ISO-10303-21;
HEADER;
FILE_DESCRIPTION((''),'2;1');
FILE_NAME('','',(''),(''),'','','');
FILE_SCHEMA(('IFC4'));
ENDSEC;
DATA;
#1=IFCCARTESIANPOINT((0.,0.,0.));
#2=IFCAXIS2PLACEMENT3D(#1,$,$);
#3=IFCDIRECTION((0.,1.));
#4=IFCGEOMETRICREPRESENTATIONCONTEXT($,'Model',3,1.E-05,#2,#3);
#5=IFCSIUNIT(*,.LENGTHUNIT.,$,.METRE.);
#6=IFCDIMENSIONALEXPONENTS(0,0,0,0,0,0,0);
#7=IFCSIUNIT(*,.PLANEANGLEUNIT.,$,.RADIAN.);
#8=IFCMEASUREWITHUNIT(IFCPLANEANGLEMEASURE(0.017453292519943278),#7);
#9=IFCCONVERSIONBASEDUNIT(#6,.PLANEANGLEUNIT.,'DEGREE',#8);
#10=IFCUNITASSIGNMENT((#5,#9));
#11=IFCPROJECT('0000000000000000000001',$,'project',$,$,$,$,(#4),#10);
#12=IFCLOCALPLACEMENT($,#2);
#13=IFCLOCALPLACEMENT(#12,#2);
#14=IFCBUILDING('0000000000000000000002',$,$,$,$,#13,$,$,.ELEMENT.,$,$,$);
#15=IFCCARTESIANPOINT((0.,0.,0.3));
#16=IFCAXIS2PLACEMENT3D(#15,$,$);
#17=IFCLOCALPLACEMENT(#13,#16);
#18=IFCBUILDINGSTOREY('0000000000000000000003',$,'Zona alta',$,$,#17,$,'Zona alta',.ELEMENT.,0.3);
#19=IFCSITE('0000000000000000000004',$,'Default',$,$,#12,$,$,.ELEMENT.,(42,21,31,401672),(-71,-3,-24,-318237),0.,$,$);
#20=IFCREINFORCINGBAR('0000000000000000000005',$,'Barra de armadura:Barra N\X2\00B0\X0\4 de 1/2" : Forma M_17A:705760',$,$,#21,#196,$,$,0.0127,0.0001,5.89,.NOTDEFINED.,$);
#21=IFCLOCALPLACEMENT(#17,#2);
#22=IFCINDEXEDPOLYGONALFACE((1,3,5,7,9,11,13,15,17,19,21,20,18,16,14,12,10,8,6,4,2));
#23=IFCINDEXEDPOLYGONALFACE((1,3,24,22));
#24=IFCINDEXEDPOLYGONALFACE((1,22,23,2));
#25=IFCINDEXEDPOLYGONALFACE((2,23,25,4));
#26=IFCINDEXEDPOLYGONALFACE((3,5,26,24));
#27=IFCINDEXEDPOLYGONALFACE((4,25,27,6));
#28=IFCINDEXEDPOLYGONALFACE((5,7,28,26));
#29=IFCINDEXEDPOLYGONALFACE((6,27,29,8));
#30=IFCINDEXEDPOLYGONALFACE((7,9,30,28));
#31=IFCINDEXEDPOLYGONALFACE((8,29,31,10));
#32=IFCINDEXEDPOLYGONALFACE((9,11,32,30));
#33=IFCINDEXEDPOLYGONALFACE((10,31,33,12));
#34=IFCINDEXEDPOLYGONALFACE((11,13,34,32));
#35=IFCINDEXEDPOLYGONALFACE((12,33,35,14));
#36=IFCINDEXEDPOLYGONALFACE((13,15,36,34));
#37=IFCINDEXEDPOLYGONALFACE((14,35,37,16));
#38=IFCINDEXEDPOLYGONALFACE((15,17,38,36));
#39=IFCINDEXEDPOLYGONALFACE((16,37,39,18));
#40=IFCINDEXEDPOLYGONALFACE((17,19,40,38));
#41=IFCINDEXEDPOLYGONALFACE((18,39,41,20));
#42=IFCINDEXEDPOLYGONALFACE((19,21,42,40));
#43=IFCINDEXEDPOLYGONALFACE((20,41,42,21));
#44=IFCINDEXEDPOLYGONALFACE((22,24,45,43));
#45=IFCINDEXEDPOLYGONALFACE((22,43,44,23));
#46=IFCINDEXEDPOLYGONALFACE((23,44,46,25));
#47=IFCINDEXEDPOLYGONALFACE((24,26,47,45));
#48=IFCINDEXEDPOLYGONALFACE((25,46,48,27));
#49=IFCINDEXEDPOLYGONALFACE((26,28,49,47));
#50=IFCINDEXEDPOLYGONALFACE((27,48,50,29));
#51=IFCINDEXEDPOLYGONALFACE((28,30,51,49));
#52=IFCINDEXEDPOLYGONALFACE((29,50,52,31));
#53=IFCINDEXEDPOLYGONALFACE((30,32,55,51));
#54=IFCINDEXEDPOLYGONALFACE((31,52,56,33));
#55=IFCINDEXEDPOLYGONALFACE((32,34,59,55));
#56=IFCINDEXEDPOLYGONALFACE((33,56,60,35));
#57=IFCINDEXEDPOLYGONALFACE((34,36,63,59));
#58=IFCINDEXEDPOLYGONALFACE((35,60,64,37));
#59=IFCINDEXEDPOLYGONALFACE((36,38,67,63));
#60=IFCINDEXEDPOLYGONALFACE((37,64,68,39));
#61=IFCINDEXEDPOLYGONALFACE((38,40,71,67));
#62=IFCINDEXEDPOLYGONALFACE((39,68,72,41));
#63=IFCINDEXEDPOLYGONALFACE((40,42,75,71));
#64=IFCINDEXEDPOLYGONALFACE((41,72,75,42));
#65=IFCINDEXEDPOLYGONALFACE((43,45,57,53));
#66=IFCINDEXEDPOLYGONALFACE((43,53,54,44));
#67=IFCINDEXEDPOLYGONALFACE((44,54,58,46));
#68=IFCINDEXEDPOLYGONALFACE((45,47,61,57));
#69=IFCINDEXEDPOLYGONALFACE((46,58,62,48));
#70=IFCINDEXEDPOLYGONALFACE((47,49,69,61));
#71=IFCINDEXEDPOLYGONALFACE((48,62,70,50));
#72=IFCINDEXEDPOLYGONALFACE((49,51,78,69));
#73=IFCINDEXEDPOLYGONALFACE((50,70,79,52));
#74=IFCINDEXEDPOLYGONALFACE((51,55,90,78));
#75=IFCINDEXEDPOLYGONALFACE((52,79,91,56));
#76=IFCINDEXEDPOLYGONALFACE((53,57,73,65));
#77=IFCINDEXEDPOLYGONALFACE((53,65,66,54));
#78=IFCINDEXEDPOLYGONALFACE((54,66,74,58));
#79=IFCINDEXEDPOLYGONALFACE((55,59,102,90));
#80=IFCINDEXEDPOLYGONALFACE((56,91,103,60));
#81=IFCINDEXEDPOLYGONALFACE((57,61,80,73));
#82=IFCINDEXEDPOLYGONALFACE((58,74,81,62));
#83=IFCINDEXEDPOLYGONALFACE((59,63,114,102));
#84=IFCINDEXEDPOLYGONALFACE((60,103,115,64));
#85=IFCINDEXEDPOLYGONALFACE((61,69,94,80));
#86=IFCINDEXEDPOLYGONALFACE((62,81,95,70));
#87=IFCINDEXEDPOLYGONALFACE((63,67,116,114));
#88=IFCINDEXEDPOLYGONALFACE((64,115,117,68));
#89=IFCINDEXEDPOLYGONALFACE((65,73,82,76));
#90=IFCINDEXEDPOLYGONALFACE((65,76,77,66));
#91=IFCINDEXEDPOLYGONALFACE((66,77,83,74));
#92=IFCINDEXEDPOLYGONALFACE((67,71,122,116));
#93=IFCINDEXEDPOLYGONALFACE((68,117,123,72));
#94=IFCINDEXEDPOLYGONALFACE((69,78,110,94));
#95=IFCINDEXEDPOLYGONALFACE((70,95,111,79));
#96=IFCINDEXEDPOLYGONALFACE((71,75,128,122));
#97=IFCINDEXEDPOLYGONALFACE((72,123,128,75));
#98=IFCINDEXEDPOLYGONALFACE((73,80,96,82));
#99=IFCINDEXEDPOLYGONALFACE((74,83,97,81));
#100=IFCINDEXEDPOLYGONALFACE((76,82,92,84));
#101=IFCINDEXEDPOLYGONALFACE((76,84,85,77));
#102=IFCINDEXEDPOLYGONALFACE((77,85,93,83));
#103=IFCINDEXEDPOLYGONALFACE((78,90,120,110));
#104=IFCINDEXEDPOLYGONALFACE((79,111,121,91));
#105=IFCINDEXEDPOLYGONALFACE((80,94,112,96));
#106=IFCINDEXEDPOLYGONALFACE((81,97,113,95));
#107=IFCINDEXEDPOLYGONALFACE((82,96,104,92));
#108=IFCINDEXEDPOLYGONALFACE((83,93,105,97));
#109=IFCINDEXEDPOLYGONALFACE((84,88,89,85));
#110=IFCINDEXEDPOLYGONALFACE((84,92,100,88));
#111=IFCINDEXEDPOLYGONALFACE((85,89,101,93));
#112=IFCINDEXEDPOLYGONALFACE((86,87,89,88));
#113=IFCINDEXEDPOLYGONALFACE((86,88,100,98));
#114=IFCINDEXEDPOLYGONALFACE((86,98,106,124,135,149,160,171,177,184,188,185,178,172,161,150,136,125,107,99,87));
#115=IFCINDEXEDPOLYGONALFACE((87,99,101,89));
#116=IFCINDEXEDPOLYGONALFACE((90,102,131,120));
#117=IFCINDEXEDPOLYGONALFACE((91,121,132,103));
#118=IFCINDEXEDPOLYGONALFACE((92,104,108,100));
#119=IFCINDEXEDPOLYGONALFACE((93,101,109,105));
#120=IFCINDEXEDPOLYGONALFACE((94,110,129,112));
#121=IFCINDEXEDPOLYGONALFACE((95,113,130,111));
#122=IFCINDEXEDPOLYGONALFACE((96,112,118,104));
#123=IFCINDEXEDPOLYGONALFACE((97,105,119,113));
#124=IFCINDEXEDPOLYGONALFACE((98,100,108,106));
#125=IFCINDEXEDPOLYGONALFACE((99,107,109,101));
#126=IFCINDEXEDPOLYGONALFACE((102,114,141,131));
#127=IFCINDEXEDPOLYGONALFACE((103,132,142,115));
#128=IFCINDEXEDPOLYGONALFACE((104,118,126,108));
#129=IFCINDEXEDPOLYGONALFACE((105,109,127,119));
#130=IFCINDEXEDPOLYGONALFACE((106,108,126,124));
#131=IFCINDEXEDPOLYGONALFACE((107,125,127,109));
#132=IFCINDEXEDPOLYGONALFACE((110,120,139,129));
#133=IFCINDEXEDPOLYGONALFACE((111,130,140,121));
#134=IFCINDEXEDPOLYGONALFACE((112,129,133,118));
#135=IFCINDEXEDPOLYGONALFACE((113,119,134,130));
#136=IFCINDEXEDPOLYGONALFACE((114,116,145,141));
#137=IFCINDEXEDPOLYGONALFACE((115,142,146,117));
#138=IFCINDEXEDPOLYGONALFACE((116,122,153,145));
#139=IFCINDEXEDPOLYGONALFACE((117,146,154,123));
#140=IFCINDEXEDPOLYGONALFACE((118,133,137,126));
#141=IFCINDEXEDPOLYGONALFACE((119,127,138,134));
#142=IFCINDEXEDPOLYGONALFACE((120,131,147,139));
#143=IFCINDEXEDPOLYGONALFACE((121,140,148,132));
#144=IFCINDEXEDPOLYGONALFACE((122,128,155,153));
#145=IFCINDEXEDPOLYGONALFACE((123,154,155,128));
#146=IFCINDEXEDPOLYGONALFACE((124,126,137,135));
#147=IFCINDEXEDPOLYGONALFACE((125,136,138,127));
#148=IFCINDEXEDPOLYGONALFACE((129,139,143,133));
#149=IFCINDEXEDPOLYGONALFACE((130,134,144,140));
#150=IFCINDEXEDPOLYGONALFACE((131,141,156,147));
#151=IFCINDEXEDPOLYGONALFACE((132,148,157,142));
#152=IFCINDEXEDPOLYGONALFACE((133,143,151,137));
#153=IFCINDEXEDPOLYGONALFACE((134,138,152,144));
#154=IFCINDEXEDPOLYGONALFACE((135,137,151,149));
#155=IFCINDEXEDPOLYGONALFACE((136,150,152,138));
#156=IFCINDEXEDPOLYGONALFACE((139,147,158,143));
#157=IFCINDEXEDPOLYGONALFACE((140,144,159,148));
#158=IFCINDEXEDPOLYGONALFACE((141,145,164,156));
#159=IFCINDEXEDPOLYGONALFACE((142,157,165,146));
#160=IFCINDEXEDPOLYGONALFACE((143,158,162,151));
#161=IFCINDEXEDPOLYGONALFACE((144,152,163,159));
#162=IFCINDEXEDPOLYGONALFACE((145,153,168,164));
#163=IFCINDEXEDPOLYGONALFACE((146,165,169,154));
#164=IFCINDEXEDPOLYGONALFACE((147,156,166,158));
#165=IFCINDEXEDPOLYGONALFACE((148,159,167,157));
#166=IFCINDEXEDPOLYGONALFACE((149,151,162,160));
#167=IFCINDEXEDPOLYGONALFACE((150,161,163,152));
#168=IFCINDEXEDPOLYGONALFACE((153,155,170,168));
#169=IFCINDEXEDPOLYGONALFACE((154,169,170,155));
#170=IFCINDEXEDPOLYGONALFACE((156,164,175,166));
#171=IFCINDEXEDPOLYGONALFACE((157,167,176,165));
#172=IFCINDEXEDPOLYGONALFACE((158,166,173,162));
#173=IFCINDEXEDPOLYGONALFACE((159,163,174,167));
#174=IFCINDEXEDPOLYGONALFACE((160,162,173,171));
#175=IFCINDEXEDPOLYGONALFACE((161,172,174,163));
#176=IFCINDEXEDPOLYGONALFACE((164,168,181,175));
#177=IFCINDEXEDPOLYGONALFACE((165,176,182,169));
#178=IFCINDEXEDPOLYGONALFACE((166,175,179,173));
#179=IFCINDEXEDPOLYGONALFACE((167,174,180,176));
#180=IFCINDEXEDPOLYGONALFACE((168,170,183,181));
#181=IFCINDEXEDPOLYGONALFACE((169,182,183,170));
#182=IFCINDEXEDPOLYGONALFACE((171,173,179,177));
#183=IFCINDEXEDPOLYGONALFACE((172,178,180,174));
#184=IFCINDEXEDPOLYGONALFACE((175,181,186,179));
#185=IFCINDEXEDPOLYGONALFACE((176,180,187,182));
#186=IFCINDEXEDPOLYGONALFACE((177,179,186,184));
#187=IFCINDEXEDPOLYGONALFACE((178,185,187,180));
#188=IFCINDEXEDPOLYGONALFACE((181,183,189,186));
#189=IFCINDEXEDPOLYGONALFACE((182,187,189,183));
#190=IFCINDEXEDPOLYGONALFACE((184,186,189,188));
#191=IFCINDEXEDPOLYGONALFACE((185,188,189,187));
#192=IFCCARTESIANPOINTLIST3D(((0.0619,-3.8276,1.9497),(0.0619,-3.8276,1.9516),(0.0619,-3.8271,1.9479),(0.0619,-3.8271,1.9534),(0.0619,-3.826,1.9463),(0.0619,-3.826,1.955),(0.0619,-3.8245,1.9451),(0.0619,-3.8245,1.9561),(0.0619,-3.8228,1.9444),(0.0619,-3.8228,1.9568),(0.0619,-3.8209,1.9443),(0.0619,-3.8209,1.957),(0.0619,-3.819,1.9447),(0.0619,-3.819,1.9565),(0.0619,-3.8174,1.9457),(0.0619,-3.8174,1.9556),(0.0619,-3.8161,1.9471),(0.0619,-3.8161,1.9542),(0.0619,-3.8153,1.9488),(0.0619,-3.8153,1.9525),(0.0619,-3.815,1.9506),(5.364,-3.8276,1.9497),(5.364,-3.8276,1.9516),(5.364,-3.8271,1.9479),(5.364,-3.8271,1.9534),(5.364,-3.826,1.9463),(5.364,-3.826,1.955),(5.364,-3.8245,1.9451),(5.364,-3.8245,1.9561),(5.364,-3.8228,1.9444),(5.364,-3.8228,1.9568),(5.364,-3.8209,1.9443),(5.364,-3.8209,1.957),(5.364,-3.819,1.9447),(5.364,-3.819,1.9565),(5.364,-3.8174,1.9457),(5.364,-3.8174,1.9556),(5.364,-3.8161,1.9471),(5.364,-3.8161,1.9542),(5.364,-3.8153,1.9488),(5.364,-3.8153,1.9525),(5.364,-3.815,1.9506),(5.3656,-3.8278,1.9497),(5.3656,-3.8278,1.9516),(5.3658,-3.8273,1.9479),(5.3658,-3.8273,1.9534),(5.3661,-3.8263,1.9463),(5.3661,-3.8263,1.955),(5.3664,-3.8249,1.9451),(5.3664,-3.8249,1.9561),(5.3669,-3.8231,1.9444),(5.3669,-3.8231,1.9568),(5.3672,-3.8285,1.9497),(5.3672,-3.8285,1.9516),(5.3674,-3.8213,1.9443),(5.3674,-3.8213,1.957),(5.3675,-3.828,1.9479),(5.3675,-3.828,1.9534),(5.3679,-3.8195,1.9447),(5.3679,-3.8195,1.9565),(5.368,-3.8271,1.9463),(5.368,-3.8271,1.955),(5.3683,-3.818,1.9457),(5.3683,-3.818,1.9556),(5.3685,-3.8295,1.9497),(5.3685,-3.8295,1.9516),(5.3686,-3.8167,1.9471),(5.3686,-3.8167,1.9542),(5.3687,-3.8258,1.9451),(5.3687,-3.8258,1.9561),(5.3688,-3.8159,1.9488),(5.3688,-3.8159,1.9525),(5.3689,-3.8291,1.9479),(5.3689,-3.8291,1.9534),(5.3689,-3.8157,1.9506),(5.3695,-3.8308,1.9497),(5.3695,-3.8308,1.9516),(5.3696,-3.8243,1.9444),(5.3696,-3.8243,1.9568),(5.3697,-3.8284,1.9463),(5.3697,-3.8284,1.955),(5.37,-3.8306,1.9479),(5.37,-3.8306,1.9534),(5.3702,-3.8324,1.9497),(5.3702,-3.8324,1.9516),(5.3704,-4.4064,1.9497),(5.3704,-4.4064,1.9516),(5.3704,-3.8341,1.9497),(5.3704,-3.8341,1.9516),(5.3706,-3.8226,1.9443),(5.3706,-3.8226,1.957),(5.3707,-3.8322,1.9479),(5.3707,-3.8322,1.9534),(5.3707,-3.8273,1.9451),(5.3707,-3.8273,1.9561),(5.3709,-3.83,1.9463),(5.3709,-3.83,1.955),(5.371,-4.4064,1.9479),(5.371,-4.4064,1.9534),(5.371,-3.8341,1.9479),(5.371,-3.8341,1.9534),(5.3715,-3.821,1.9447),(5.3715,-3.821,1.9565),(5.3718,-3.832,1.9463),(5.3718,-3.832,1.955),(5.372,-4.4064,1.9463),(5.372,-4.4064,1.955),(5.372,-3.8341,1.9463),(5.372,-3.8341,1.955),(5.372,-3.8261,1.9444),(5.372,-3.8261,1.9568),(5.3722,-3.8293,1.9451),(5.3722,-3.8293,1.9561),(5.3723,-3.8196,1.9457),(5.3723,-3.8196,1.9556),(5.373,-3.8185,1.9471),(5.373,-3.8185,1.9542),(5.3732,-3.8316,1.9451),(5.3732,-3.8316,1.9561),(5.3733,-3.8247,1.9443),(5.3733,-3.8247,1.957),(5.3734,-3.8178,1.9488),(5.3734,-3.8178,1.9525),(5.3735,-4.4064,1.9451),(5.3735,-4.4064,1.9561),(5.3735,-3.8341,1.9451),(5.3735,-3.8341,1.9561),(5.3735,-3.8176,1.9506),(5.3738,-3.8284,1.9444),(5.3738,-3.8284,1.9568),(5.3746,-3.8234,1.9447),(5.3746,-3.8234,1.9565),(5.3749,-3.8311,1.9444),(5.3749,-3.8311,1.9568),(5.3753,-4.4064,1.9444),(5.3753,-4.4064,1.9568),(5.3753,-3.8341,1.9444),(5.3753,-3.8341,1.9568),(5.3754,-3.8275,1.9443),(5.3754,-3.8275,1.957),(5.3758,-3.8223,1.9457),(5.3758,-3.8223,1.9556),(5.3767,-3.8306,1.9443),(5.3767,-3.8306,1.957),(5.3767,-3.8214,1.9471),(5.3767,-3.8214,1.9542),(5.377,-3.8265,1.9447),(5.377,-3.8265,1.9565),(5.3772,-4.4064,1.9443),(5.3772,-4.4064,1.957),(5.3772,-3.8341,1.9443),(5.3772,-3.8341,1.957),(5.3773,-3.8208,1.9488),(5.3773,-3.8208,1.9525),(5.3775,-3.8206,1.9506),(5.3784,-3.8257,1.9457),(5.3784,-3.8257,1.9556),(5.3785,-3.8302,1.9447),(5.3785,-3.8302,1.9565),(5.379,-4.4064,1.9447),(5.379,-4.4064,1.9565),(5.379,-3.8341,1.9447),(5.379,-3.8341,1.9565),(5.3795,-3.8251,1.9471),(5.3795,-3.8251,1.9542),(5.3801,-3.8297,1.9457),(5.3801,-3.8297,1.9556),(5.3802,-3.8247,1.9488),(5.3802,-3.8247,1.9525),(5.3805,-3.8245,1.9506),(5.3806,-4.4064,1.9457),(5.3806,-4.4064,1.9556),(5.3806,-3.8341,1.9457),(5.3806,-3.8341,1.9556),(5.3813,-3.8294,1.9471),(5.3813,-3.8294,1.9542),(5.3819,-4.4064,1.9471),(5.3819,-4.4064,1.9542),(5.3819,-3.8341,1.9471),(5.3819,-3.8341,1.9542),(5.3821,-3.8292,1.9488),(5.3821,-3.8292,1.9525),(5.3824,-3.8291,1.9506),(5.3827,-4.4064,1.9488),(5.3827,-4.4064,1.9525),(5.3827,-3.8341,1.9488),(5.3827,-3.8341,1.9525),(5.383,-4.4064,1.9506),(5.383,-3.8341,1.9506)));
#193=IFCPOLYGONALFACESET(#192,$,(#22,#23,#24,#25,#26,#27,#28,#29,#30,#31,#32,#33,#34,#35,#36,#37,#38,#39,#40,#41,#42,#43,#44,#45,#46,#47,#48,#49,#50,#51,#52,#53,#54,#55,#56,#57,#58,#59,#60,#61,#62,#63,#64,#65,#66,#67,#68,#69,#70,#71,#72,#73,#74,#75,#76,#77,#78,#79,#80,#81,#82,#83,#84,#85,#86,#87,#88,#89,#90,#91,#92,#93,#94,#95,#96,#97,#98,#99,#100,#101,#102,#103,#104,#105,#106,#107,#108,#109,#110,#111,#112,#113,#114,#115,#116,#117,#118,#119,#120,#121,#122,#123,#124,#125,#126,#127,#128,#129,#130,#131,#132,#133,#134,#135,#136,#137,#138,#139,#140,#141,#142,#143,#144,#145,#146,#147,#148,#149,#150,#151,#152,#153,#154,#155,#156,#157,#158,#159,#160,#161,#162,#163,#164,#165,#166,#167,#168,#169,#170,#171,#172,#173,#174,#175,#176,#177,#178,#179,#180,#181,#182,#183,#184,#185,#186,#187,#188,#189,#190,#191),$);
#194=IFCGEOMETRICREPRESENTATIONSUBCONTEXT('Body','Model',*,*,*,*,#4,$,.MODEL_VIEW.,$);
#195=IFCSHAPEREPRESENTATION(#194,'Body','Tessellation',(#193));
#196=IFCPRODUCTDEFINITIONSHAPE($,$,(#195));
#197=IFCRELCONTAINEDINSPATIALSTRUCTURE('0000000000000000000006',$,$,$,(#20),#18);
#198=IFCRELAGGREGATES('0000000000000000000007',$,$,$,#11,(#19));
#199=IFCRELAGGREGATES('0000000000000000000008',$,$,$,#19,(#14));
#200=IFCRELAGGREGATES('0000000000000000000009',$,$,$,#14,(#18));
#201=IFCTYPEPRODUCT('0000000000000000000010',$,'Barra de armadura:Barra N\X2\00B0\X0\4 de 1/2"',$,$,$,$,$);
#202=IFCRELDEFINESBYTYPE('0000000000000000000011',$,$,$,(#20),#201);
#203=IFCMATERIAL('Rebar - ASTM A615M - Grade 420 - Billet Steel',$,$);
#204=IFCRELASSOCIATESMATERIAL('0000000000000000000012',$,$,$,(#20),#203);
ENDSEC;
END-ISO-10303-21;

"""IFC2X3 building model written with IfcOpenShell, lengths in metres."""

from ifc_helpers import new_model, entity, si_unit, converted_unit, direction, frame, origin, place, context, subcontext, project, spatial, material, type_object, element, save


model = new_model("IFC2X3")

# Units and contexts
model_context = context("Model", 3, precision=1e-05, world=origin(), true_north=direction((0.0, 1.0)))
body_context = subcontext(model_context, "Body", "Model", "MODEL_VIEW")
ifc_project = project(units=[si_unit("LENGTHUNIT", "METRE"), converted_unit("PLANEANGLEUNIT", "DEGREE", entity("IfcPlaneAngleMeasure", 0.017453292519943278), si_unit("PLANEANGLEUNIT", "RADIAN"), dimensions=[0, 0, 0, 0, 0, 0, 0])], contexts=[model_context])

# Site, building, storey
site_placement = place(None, origin())
site = spatial("IfcSite", under=ifc_project, at=site_placement, Name="Default", CompositionType="ELEMENT", RefLatitude=(42, 21, 31, 401672), RefLongitude=(-71, -3, -24, -318237), RefElevation=0.0)
building_placement = place(site_placement, origin())
building = spatial("IfcBuilding", under=site, at=building_placement, CompositionType="ELEMENT")
storey_placement = place(building_placement, frame((0.0, 0.0, 0.3)))
storey = spatial("IfcBuildingStorey", under=building, at=storey_placement, Name="Zona alta", LongName="Zona alta", CompositionType="ELEMENT", Elevation=0.3)

# Reinforcing bar
ifc_material = material(Name="Rebar - ASTM A615M - Grade 420 - Billet Steel")
type_product_1 = type_object("IfcTypeProduct", Name="Barra de armadura:Barra N°4 de 1/2\"")
reinforcing_bar_1_placement = place(storey_placement, origin())
element("IfcReinforcingBar", 1, at=reinforcing_bar_1_placement, inside=storey, type_object=type_product_1, material=ifc_material, Name="Barra de armadura:Barra N°4 de 1/2\" : Forma M_17A:705760", BarLength=5.89, BarRole="NOTDEFINED", CrossSectionArea=0.0001, NominalDiameter=0.0127, context=body_context, shape_type="AdvancedSweptSolid", body=[
    entity("IfcSweptDiskSolid", entity("IfcCompositeCurve", [entity("IfcCompositeCurveSegment", "CONTINUOUS", True, entity("IfcPolyline", [entity("IfcCartesianPoint", [0.0619, -3.8214, 1.9506]), entity("IfcCartesianPoint", [5.364, -3.8214, 1.9506])])), entity("IfcCompositeCurveSegment", "CONTINUOUS", True, entity("IfcTrimmedCurve", entity("IfcCircle", entity("IfcAxis2Placement3D", entity("IfcCartesianPoint", [5.364, -3.8341, 1.9506]), entity("IfcDirection", [0.0, 0.0, -1.0]), entity("IfcDirection", [1.0, 0.0, 0.0])), 0.0127), [entity("IfcParameterValue", 270.0)], [entity("IfcParameterValue", 360.0)], True, "PARAMETER")), entity("IfcCompositeCurveSegment", "CONTINUOUS", True, entity("IfcPolyline", [entity("IfcCartesianPoint", [5.3767, -3.8341, 1.9506]), entity("IfcCartesianPoint", [5.3767, -4.4064, 1.9506])]))], False), 0.0063, None, 0.0, 92.0),
])

save(model, "model.ifc")
